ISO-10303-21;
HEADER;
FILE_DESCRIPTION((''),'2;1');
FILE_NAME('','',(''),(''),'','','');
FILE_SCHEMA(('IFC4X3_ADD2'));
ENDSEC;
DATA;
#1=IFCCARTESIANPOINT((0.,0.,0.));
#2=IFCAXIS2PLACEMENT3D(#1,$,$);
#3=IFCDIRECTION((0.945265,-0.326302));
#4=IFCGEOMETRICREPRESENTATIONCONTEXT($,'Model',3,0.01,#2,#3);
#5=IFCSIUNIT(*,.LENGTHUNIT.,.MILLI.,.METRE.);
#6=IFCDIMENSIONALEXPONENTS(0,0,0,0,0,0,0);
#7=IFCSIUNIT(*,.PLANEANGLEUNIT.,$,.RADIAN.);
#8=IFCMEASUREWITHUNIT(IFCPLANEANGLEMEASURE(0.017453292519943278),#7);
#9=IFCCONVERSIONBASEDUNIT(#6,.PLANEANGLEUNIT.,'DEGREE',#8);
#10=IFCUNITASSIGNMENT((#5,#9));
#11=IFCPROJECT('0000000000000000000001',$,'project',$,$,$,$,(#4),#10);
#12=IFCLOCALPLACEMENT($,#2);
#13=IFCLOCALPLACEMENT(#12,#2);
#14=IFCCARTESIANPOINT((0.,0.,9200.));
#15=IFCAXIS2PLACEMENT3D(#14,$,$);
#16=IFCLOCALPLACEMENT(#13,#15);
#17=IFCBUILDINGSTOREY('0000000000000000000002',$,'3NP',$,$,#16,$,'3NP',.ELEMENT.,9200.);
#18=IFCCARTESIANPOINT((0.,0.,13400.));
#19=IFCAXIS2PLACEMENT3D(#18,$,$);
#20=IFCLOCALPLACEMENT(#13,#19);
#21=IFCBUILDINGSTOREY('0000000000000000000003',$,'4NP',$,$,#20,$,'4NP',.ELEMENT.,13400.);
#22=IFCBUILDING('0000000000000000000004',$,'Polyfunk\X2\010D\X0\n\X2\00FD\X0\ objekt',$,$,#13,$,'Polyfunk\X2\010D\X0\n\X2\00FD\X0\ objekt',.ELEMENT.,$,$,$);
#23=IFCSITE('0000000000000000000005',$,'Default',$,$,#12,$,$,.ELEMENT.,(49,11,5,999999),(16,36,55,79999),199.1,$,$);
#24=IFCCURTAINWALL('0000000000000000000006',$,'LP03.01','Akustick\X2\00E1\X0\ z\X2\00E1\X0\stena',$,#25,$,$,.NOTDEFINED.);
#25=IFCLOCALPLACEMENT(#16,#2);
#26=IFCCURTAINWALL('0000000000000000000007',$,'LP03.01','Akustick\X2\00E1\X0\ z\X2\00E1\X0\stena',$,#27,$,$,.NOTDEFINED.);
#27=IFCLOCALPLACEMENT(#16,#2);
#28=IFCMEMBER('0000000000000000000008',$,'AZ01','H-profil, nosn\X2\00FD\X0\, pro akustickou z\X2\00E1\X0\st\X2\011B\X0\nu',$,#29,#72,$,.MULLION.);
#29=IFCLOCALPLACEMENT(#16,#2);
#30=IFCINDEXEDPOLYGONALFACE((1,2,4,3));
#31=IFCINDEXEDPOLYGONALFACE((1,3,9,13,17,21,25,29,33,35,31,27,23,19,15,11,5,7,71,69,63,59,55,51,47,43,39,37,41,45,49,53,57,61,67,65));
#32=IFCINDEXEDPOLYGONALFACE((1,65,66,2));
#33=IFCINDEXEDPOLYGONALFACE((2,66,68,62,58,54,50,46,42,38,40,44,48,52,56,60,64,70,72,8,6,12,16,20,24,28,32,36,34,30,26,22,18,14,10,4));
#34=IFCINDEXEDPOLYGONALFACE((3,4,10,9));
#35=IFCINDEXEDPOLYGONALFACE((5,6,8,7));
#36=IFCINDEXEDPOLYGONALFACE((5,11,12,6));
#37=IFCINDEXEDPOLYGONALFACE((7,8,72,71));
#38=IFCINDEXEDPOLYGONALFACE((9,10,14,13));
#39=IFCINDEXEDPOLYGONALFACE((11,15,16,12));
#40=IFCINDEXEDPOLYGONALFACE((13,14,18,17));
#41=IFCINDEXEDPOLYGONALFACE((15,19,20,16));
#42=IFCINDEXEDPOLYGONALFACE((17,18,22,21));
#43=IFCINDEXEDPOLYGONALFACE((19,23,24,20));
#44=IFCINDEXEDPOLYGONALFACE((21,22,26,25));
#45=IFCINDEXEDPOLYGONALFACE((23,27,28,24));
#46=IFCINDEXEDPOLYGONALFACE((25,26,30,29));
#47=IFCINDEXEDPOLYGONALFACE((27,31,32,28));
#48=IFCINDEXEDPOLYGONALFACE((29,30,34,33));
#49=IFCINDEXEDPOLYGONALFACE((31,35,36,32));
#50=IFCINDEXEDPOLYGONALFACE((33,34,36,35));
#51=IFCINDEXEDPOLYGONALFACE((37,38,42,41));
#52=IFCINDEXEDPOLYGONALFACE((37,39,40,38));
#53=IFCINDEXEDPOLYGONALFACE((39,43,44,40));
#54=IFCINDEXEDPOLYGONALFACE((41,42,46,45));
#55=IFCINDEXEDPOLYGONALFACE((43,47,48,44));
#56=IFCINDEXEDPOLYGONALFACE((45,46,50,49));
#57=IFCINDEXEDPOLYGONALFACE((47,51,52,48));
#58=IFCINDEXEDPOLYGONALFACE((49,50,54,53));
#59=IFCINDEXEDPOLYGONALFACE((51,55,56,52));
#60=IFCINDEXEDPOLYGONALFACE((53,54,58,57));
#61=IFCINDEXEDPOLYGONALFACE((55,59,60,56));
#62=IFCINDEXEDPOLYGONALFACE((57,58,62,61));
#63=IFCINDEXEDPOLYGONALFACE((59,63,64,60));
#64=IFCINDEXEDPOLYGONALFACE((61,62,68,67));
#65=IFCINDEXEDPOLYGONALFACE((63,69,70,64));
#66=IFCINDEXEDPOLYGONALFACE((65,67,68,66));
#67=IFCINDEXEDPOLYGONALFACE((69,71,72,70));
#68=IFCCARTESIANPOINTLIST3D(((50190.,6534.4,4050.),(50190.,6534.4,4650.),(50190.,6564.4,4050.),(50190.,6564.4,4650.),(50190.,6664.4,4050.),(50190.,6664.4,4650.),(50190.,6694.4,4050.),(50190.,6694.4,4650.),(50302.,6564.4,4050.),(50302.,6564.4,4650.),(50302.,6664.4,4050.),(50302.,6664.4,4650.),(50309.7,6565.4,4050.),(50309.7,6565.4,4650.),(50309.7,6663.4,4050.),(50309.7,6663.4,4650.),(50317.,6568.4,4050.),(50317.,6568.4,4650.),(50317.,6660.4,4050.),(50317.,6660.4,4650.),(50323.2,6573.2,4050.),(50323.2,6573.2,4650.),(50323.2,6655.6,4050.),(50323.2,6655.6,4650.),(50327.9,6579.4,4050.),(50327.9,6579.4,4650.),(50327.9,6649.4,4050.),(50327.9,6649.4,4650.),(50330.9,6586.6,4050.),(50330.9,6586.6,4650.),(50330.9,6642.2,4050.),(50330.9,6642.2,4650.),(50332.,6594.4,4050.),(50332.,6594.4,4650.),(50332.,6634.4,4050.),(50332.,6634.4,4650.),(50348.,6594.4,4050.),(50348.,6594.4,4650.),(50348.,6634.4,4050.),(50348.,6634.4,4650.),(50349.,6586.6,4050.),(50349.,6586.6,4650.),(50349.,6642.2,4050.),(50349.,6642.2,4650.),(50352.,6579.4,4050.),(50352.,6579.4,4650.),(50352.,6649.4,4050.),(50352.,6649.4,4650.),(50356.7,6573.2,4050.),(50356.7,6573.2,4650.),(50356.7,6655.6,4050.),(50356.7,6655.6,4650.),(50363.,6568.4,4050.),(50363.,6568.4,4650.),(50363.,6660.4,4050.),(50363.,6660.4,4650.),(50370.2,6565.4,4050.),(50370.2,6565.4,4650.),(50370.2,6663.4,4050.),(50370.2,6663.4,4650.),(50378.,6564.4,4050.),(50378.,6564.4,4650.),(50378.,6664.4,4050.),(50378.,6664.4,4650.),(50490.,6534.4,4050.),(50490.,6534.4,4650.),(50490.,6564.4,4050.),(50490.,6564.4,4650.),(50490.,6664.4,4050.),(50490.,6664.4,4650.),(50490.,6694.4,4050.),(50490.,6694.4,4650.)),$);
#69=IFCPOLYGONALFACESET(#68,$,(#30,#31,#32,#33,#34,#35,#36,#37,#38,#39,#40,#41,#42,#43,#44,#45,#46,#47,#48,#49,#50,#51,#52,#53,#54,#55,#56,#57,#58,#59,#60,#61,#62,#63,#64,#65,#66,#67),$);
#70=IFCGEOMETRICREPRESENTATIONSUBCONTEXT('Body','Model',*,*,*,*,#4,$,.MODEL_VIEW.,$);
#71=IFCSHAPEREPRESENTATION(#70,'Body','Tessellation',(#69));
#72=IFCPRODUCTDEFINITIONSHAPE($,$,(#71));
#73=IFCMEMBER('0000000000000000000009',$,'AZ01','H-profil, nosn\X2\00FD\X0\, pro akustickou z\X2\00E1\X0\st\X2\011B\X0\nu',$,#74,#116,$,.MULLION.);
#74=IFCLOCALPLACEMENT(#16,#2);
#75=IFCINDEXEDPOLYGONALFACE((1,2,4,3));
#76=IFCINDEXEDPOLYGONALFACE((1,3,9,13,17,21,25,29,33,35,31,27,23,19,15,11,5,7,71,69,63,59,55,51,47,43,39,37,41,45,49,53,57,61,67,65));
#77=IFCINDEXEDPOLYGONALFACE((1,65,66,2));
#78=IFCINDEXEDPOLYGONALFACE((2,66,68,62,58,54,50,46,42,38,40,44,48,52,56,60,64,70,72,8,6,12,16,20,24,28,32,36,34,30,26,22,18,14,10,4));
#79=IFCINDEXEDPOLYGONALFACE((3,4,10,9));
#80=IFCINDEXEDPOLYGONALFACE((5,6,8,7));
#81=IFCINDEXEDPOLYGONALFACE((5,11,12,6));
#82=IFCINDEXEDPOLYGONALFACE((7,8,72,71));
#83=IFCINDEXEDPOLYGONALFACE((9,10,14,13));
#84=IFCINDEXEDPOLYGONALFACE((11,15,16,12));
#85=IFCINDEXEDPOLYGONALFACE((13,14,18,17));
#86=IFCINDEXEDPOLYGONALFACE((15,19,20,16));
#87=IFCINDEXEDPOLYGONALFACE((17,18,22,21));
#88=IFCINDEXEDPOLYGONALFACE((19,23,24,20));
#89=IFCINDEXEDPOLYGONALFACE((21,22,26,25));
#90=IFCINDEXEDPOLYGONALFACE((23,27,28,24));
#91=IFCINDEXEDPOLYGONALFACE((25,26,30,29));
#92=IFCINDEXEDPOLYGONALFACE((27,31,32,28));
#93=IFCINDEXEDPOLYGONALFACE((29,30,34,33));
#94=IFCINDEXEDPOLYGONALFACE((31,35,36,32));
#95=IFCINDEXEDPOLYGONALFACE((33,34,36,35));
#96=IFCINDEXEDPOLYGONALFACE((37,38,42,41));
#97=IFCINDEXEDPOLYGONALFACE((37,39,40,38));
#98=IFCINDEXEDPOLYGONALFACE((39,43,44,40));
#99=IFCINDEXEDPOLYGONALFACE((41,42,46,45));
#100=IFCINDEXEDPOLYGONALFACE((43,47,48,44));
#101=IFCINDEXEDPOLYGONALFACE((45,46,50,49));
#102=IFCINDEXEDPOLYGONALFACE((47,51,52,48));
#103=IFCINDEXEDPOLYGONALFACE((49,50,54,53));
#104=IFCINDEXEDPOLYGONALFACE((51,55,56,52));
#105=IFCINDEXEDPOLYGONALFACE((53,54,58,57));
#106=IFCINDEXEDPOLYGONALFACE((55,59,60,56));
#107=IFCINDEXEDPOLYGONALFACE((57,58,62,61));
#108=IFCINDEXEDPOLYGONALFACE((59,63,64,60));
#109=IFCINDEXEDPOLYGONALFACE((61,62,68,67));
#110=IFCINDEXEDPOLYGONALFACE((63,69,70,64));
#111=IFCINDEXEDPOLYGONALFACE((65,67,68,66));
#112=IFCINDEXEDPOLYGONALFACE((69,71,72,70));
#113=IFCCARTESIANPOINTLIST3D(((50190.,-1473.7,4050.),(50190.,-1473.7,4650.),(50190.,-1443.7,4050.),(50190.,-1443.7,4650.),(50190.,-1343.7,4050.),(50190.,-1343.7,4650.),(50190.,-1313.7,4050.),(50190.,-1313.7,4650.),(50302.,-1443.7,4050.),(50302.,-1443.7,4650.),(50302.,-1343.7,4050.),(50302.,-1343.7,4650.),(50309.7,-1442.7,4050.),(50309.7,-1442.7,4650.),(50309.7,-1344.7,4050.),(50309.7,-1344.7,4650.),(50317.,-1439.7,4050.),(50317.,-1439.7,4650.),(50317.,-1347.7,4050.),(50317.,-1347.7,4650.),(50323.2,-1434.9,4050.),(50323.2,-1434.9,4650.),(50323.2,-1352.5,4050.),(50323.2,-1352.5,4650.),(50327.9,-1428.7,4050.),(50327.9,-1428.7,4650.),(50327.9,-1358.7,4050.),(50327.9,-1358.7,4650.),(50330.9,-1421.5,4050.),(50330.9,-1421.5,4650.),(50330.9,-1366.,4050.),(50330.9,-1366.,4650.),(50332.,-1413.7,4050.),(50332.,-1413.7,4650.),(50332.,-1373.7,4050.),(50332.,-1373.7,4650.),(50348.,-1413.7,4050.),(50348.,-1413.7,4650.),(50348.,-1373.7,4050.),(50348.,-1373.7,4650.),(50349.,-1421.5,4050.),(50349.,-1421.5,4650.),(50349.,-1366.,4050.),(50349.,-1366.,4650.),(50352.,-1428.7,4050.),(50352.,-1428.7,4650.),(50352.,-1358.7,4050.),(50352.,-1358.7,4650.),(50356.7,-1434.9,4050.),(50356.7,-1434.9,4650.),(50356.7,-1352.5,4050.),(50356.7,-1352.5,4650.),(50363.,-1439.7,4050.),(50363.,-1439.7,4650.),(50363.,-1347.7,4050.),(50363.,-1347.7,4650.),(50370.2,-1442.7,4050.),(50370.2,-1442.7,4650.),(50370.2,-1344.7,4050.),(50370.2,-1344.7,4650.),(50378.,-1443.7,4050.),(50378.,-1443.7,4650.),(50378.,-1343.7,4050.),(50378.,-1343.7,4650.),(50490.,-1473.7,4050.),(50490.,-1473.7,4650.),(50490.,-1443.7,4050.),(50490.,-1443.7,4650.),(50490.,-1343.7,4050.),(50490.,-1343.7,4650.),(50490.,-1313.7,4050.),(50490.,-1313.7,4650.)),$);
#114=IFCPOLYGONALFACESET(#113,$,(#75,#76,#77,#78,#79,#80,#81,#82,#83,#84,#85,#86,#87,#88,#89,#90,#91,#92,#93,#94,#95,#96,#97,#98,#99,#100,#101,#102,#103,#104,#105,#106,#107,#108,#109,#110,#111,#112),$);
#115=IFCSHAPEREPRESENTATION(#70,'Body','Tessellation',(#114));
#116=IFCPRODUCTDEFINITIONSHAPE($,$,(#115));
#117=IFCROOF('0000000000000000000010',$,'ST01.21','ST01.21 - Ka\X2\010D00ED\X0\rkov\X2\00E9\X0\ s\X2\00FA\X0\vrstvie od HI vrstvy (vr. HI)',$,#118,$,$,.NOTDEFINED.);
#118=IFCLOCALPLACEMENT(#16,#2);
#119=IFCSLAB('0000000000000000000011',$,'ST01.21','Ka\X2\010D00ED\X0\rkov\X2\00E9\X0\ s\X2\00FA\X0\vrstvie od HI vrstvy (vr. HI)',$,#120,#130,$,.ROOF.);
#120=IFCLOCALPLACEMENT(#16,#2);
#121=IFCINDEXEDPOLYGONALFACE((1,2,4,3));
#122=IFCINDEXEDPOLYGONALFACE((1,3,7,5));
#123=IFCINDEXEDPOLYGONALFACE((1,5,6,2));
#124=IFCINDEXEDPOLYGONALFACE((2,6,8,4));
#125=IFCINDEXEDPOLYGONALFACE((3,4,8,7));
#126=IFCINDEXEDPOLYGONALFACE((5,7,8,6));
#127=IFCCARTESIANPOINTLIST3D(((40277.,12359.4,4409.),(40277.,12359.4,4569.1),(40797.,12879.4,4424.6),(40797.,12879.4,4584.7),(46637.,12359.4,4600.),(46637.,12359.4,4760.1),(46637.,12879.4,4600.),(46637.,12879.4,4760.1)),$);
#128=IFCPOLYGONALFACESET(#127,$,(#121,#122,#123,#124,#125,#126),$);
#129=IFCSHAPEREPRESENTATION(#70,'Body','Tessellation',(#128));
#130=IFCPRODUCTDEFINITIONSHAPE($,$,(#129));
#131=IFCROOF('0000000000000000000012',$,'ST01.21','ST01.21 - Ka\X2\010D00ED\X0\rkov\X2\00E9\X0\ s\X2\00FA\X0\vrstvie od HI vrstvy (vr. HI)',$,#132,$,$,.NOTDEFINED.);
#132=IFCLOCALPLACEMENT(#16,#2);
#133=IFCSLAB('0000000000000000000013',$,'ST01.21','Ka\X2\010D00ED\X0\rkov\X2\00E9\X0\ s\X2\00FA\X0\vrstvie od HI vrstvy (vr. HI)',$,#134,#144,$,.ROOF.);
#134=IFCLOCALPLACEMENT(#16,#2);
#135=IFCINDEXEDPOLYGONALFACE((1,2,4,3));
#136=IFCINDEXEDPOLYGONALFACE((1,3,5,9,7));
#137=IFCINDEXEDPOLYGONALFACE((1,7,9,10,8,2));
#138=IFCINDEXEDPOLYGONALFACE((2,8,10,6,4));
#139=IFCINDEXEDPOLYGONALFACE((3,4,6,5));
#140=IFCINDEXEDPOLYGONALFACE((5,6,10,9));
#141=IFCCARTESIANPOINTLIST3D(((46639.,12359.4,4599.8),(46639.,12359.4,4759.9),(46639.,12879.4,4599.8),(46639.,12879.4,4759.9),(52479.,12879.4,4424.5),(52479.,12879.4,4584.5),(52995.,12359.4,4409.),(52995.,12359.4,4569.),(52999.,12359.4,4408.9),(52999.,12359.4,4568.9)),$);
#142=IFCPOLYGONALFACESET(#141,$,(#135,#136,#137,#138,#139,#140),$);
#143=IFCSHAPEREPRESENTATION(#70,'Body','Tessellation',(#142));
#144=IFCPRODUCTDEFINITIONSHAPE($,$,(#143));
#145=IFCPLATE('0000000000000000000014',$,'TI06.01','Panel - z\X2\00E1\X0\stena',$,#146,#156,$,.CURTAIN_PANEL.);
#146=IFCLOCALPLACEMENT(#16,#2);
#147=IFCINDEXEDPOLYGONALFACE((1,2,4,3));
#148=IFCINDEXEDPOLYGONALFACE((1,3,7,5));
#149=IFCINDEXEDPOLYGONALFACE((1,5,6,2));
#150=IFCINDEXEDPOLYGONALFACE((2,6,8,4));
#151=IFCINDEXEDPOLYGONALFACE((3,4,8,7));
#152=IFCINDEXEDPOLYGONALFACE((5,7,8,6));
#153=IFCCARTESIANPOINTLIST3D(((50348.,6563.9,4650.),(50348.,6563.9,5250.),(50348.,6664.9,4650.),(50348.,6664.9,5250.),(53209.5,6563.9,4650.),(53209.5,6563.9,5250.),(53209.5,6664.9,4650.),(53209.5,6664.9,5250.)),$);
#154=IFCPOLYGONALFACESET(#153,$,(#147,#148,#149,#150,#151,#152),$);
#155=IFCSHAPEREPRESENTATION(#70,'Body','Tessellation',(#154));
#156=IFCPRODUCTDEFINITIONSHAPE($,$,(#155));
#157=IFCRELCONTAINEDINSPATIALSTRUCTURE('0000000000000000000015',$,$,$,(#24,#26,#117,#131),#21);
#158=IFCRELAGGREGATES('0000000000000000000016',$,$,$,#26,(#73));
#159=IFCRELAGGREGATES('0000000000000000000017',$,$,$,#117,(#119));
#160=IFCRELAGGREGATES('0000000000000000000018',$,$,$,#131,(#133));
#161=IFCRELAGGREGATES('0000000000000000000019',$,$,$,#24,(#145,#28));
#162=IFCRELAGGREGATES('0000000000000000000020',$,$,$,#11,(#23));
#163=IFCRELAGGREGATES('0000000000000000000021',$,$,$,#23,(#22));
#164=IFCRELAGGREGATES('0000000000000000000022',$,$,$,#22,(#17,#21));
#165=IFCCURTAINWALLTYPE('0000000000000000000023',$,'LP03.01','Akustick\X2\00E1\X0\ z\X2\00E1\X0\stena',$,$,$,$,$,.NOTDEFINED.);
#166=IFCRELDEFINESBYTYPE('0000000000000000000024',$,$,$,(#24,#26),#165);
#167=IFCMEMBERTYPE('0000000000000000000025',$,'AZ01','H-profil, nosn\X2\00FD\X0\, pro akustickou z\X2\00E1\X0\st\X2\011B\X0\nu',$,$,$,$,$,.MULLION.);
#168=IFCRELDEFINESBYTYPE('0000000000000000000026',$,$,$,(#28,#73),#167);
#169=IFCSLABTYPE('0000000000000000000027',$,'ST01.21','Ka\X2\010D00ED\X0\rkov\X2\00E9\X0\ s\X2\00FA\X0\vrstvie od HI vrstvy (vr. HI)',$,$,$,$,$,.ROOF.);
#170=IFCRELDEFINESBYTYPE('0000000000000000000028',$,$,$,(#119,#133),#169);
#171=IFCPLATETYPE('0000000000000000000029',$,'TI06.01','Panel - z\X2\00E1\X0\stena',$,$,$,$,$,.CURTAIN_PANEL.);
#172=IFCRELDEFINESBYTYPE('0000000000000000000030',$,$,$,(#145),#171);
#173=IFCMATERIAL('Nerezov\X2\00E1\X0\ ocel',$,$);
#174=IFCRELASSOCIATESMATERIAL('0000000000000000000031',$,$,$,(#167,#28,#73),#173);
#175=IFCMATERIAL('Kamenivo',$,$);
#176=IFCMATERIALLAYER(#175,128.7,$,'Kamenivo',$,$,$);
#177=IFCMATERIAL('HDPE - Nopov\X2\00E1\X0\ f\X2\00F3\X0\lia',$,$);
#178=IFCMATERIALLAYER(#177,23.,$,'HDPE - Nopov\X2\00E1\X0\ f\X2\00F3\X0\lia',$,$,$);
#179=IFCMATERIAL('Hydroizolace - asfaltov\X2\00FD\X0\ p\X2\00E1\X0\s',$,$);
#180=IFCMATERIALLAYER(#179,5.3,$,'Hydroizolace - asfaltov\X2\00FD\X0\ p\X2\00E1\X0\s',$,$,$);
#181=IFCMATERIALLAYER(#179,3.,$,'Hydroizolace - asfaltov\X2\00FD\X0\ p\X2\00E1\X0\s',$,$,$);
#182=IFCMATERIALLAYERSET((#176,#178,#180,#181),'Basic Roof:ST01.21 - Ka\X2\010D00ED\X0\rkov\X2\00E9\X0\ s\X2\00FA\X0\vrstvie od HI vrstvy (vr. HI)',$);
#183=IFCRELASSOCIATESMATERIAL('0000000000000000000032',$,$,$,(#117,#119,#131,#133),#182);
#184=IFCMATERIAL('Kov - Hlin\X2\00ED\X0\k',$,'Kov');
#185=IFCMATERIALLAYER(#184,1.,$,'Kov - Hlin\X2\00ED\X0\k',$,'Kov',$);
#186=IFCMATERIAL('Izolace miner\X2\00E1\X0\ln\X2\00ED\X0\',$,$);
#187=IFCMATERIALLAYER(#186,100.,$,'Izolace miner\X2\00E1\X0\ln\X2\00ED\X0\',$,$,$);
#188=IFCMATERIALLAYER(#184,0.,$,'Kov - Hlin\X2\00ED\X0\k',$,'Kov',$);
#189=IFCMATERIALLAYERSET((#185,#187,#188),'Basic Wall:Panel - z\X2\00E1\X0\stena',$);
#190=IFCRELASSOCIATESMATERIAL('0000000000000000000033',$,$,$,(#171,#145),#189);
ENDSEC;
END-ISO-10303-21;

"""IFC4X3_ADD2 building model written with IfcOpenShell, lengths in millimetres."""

from ifc_helpers import new_model, entity, si_unit, converted_unit, direction, frame, frame_2d, origin, place, context, subcontext, project, spatial, polyline, circle_curve, parameter, trimmed, segment, composite_curve, rectangle, outline, extrude, source, transform, mapped, material, layer, layer_set, layer_usage, material_profile, profile_set, profile_usage, type_object, element, aggregate, save


model = new_model("IFC4X3_ADD2")

# Units and contexts
model_context = context("Model", 3, precision=0.01, world=origin(), true_north=direction((0.945265, -0.326302)))
body_context = subcontext(model_context, "Body", "Model", "MODEL_VIEW")
ifc_project = project(units=[si_unit("LENGTHUNIT", "METRE", prefix="MILLI"), converted_unit("PLANEANGLEUNIT", "DEGREE", entity("IfcPlaneAngleMeasure", 0.017453292519943278), si_unit("PLANEANGLEUNIT", "RADIAN"), dimensions=[0, 0, 0, 0, 0, 0, 0])], contexts=[model_context])

# Site, building, storey
site_placement = place(None, origin())
site = spatial("IfcSite", under=ifc_project, at=site_placement, Name="Default", CompositionType="ELEMENT", RefLatitude=(49, 11, 5, 999999), RefLongitude=(16, 36, 55, 79999), RefElevation=199.1)
building_placement = place(site_placement, origin())
building = spatial("IfcBuilding", under=site, at=building_placement, Name="Polyfunkčný objekt", LongName="Polyfunkčný objekt", CompositionType="ELEMENT")
storey_1_placement = place(building_placement, frame((0.0, 0.0, 9200.0)))
storey_1 = spatial("IfcBuildingStorey", under=building, at=storey_1_placement, Name="3NP", LongName="3NP", CompositionType="ELEMENT", Elevation=9200.0)

# Shared definitions
storey_2_placement = place(building_placement, frame((0.0, 0.0, 13400.0)))
storey_2 = spatial("IfcBuildingStorey", under=building, at=storey_2_placement, Name="4NP", LongName="4NP", CompositionType="ELEMENT", Elevation=13400.0)

# Curtain walls
curtain_wall_type_1 = type_object("IfcCurtainWallType", Name="LP03.01", Description="Akustická zástena", PredefinedType="NOTDEFINED")
curtain_wall_1_placement = place(storey_2_placement, frame((0.0, 0.0, -13400.0)))
curtain_wall_1 = element("IfcCurtainWall", 1, at=curtain_wall_1_placement, inside=storey_2, type_object=curtain_wall_type_1, Name="LP03.01", Description="Akustická zástena", PredefinedType="NOTDEFINED")
ifc_material_1 = material(Name="Nerezová ocel")
ifc_material_profile_1 = material_profile(ifc_material_1, outline(composite_curve([segment(polyline([(50.0, -150.0), (80.0, -150.0)]), True, "CONTINUOUS"), segment(polyline([(80.0, -150.0), (80.0, 150.0)]), True, "CONTINUOUS"), segment(polyline([(80.0, 150.0), (50.0, 150.0)]), True, "CONTINUOUS"), segment(polyline([(50.0, 150.0), (50.0, 38.0)]), True, "CONTINUOUS"), segment(trimmed(circle_curve(frame_2d((20.0, 38.0), x_axis=(0.0, 1.0)), 30.0), [parameter(180.0)], [parameter(270.0)], True, "PARAMETER"), False, "CONTINUOUS"), segment(polyline([(20.0, 8.0), (-20.0, 8.0)]), True, "CONTINUOUS"), segment(trimmed(circle_curve(frame_2d((-20.0, 38.0), x_axis=(0.0, 1.0)), 30.0), [parameter(90.0)], [parameter(180.0)], True, "PARAMETER"), False, "CONTINUOUS"), segment(polyline([(-50.0, 38.0), (-50.0, 150.0)]), True, "CONTINUOUS"), segment(polyline([(-50.0, 150.0), (-80.0, 150.0)]), True, "CONTINUOUS"), segment(polyline([(-80.0, 150.0), (-80.0, -150.0)]), True, "CONTINUOUS"), segment(polyline([(-80.0, -150.0), (-50.0, -150.0)]), True, "CONTINUOUS"), segment(polyline([(-50.0, -150.0), (-50.0, -38.0)]), True, "CONTINUOUS"), segment(trimmed(circle_curve(frame_2d((-20.0, -38.0), x_axis=(0.0, 1.0)), 30.0), [parameter(0.0)], [parameter(90.0)], True, "PARAMETER"), False, "CONTINUOUS"), segment(polyline([(-20.0, -8.0), (20.0, -8.0)]), True, "CONTINUOUS"), segment(trimmed(circle_curve(frame_2d((20.0, -38.0), x_axis=(0.0, 1.0)), 30.0), [parameter(270.0)], [parameter(0.0)], True, "PARAMETER"), False, "CONTINUOUS"), segment(polyline([(50.0, -38.0), (50.0, -150.0)]), True, "CONTINUOUS")], self_intersect=False)), Name="Profil zástena")
ifc_profile_set_1 = profile_set([ifc_material_profile_1], Name="Profil zástena")
ifc_profile_usage_1 = profile_usage(ifc_profile_set_1)
member_type_1 = type_object("IfcMemberType", Name="AZ01", Description="H-profil, nosný, pro akustickou zástěnu", PredefinedType="MULLION", material=ifc_profile_set_1)
curtain_wall_2_placement = place(storey_2_placement, frame((0.0, 0.0, -13400.0)))
curtain_wall_2 = element("IfcCurtainWall", 2, at=curtain_wall_2_placement, inside=storey_2, type_object=curtain_wall_type_1, Name="LP03.01", Description="Akustická zástena", PredefinedType="NOTDEFINED")

# Members
shared_shape_1 = source(origin(), body_context, "Body", "SweptSolid", [
    extrude(outline(composite_curve([segment(polyline([(-150.0, -50.0), (-150.0, -80.0)]), True, "CONTINUOUS"), segment(polyline([(-150.0, -80.0), (150.0, -80.0)]), True, "CONTINUOUS"), segment(polyline([(150.0, -80.0), (150.0, -50.0)]), True, "CONTINUOUS"), segment(polyline([(150.0, -50.0), (38.0, -50.0)]), True, "CONTINUOUS"), segment(trimmed(circle_curve(frame_2d((38.0, -20.0), x_axis=(1.0, 0.0)), 30.0), [parameter(180.0)], [parameter(270.0)], True, "PARAMETER"), False, "CONTINUOUS"), segment(polyline([(8.0, -20.0), (8.0, 20.0)]), True, "CONTINUOUS"), segment(trimmed(circle_curve(frame_2d((38.0, 20.0), x_axis=(1.0, 0.0)), 30.0), [parameter(90.0)], [parameter(180.0)], True, "PARAMETER"), False, "CONTINUOUS"), segment(polyline([(38.0, 50.0), (150.0, 50.0)]), True, "CONTINUOUS"), segment(polyline([(150.0, 50.0), (150.0, 80.0)]), True, "CONTINUOUS"), segment(polyline([(150.0, 80.0), (-150.0, 80.0)]), True, "CONTINUOUS"), segment(polyline([(-150.0, 80.0), (-150.0, 50.0)]), True, "CONTINUOUS"), segment(polyline([(-150.0, 50.0), (-38.0, 50.0)]), True, "CONTINUOUS"), segment(trimmed(circle_curve(frame_2d((-38.0, 20.0), x_axis=(1.0, 0.0)), 30.0), [parameter(0.0)], [parameter(90.0)], True, "PARAMETER"), False, "CONTINUOUS"), segment(polyline([(-8.0, 20.0), (-8.0, -20.0)]), True, "CONTINUOUS"), segment(trimmed(circle_curve(frame_2d((-38.0, -20.0), x_axis=(1.0, 0.0)), 30.0), [parameter(270.0)], [parameter(0.0)], True, "PARAMETER"), False, "CONTINUOUS"), segment(polyline([(-38.0, -50.0), (-150.0, -50.0)]), True, "CONTINUOUS")], self_intersect=False)), frame((-150.0, 0.0, -600.0), z_axis=(0.0, 0.0, -1.0), x_axis=(-1.0, 0.0, 0.0)), (0.0, 0.0, -1.0), 600.0),
])
member_1_placement = place(curtain_wall_1_placement, frame((50190.0, 6614.4, 13850.0), z_axis=(0.0, 0.0, 1.0), x_axis=(-1.0, 0.0, 0.0)))
member_1 = element("IfcMember", 3, at=member_1_placement, type_object=member_type_1, material=ifc_profile_usage_1, Name="AZ01", Description="H-profil, nosný, pro akustickou zástěnu", PredefinedType="MULLION", context=body_context, shape_type="MappedRepresentation", body=[
    mapped(shared_shape_1, transform((0.0, 0.0, 0.0), scale=1.0)),
])
member_2_placement = place(curtain_wall_2_placement, frame((50190.0, -1393.7, 13850.0), z_axis=(0.0, 0.0, 1.0), x_axis=(-1.0, 0.0, 0.0)))
member_2 = element("IfcMember", 4, at=member_2_placement, type_object=member_type_1, material=ifc_profile_usage_1, Name="AZ01", Description="H-profil, nosný, pro akustickou zástěnu", PredefinedType="MULLION", context=body_context, shape_type="MappedRepresentation", body=[
    mapped(shared_shape_1, transform((0.0, 0.0, 0.0), scale=1.0)),
])
aggregate(curtain_wall_2, [member_2])

# Roofs, slabs
ifc_material_2 = material(Name="Kamenivo")
ifc_layer_1 = layer(ifc_material_2, 128.7, Name="Kamenivo")
ifc_material_3 = material(Name="HDPE - Nopová fólia")
ifc_layer_2 = layer(ifc_material_3, 23.0, Name="HDPE - Nopová fólia")
ifc_material_4 = material(Name="Hydroizolace - asfaltový pás")
ifc_layer_3 = layer(ifc_material_4, 5.3, Name="Hydroizolace - asfaltový pás")
ifc_layer_4 = layer(ifc_material_4, 3.0, Name="Hydroizolace - asfaltový pás")
ifc_layer_set_1 = layer_set([ifc_layer_1, ifc_layer_2, ifc_layer_3, ifc_layer_4], Name="Basic Roof:ST01.21 - Kačírkové súvrstvie od HI vrstvy (vr. HI)")
roof_1_placement = place(storey_2_placement, frame((40277.0, 12359.4, 209.0)))
roof_1 = element("IfcRoof", 5, at=roof_1_placement, inside=storey_2, material=ifc_layer_set_1, Name="ST01.21", Description="ST01.21 - Kačírkové súvrstvie od HI vrstvy (vr. HI)", PredefinedType="NOTDEFINED")
slab_type = type_object("IfcSlabType", Name="ST01.21", Description="Kačírkové súvrstvie od HI vrstvy (vr. HI)", PredefinedType="ROOF")
slab_1_placement = place(roof_1_placement, origin())
slab_1 = element("IfcSlab", 6, at=slab_1_placement, type_object=slab_type, material=ifc_layer_set_1, Name="ST01.21", Description="Kačírkové súvrstvie od HI vrstvy (vr. HI)", PredefinedType="ROOF", context=body_context, shape_type="SweptSolid", body=[
    extrude(outline(polyline([(-3181.4, -260.0), (3181.4, -260.0), (3181.4, 260.0), (-2661.2, 260.0), (-3181.4, -260.0)])), frame((3180.0, 260.0, 95.5), z_axis=(-0.030015, 0.0, 0.999549), x_axis=(0.999549, 0.0, 0.030015)), (0.030015, 0.0, 0.999549), 160.1),
])
aggregate(roof_1, [slab_1])
roof_2_placement = place(storey_2_placement, frame((46639.0, 12359.4, 208.9)))
roof_2 = element("IfcRoof", 7, at=roof_2_placement, inside=storey_2, material=ifc_layer_set_1, Name="ST01.21", Description="ST01.21 - Kačírkové súvrstvie od HI vrstvy (vr. HI)", PredefinedType="NOTDEFINED")
slab_2_placement = place(roof_2_placement, origin())
slab_2 = element("IfcSlab", 8, at=slab_2_placement, type_object=slab_type, material=ifc_layer_set_1, Name="ST01.21", Description="Kačírkové súvrstvie od HI vrstvy (vr. HI)", PredefinedType="ROOF", context=body_context, shape_type="SweptSolid", body=[
    extrude(outline(polyline([(2661.2, 260.0), (-3181.4, 260.0), (-3181.4, -260.0), (3177.4, -260.0), (3181.4, -260.0), (2661.2, 260.0)])), frame((3180.0, 260.0, 95.5), z_axis=(0.030015, 0.0, 0.999549), x_axis=(0.999549, 0.0, -0.030015)), (-0.030015, 0.0, 0.999549), 160.1),
])
aggregate(roof_2, [slab_2])

# Plate
ifc_material_5 = material(Name="Kov - Hliník", Category="Kov")
ifc_layer_5 = layer(ifc_material_5, 1.0, Name="Kov - Hliník", Category="Kov")
ifc_material_6 = material(Name="Izolace minerální")
ifc_layer_6 = layer(ifc_material_6, 100.0, Name="Izolace minerální")
ifc_layer_7 = layer(ifc_material_5, 0.0, Name="Kov - Hliník", Category="Kov")
ifc_layer_set_2 = layer_set([ifc_layer_5, ifc_layer_6, ifc_layer_7], Name="Basic Wall:Panel - zástena")
ifc_layer_usage_1 = layer_usage(ifc_layer_set_2, "AXIS2", "POSITIVE", -50.5)
plate_type = type_object("IfcPlateType", Name="TI06.01", Description="Panel - zástena", PredefinedType="CURTAIN_PANEL", material=ifc_layer_set_2)
plate_1_placement = place(storey_2_placement, frame((50348.0, 6614.4, 450.0)))
plate_1 = element("IfcPlate", 9, at=plate_1_placement, type_object=plate_type, material=ifc_layer_usage_1, Name="TI06.01", Description="Panel - zástena", PredefinedType="CURTAIN_PANEL", context=body_context, shape_type="SweptSolid", body=[
    extrude(rectangle(XDim=101.0, YDim=2861.5, at=frame_2d((0.0, 0.0), x_axis=(1.0, 0.0))), frame((1430.7, 0.0, 0.0), z_axis=(0.0, 0.0, 1.0), x_axis=(0.0, 1.0, 0.0)), (0.0, 0.0, 1.0), 600.0),
])
aggregate(curtain_wall_1, [plate_1, member_1])

save(model, "model.ifc")
